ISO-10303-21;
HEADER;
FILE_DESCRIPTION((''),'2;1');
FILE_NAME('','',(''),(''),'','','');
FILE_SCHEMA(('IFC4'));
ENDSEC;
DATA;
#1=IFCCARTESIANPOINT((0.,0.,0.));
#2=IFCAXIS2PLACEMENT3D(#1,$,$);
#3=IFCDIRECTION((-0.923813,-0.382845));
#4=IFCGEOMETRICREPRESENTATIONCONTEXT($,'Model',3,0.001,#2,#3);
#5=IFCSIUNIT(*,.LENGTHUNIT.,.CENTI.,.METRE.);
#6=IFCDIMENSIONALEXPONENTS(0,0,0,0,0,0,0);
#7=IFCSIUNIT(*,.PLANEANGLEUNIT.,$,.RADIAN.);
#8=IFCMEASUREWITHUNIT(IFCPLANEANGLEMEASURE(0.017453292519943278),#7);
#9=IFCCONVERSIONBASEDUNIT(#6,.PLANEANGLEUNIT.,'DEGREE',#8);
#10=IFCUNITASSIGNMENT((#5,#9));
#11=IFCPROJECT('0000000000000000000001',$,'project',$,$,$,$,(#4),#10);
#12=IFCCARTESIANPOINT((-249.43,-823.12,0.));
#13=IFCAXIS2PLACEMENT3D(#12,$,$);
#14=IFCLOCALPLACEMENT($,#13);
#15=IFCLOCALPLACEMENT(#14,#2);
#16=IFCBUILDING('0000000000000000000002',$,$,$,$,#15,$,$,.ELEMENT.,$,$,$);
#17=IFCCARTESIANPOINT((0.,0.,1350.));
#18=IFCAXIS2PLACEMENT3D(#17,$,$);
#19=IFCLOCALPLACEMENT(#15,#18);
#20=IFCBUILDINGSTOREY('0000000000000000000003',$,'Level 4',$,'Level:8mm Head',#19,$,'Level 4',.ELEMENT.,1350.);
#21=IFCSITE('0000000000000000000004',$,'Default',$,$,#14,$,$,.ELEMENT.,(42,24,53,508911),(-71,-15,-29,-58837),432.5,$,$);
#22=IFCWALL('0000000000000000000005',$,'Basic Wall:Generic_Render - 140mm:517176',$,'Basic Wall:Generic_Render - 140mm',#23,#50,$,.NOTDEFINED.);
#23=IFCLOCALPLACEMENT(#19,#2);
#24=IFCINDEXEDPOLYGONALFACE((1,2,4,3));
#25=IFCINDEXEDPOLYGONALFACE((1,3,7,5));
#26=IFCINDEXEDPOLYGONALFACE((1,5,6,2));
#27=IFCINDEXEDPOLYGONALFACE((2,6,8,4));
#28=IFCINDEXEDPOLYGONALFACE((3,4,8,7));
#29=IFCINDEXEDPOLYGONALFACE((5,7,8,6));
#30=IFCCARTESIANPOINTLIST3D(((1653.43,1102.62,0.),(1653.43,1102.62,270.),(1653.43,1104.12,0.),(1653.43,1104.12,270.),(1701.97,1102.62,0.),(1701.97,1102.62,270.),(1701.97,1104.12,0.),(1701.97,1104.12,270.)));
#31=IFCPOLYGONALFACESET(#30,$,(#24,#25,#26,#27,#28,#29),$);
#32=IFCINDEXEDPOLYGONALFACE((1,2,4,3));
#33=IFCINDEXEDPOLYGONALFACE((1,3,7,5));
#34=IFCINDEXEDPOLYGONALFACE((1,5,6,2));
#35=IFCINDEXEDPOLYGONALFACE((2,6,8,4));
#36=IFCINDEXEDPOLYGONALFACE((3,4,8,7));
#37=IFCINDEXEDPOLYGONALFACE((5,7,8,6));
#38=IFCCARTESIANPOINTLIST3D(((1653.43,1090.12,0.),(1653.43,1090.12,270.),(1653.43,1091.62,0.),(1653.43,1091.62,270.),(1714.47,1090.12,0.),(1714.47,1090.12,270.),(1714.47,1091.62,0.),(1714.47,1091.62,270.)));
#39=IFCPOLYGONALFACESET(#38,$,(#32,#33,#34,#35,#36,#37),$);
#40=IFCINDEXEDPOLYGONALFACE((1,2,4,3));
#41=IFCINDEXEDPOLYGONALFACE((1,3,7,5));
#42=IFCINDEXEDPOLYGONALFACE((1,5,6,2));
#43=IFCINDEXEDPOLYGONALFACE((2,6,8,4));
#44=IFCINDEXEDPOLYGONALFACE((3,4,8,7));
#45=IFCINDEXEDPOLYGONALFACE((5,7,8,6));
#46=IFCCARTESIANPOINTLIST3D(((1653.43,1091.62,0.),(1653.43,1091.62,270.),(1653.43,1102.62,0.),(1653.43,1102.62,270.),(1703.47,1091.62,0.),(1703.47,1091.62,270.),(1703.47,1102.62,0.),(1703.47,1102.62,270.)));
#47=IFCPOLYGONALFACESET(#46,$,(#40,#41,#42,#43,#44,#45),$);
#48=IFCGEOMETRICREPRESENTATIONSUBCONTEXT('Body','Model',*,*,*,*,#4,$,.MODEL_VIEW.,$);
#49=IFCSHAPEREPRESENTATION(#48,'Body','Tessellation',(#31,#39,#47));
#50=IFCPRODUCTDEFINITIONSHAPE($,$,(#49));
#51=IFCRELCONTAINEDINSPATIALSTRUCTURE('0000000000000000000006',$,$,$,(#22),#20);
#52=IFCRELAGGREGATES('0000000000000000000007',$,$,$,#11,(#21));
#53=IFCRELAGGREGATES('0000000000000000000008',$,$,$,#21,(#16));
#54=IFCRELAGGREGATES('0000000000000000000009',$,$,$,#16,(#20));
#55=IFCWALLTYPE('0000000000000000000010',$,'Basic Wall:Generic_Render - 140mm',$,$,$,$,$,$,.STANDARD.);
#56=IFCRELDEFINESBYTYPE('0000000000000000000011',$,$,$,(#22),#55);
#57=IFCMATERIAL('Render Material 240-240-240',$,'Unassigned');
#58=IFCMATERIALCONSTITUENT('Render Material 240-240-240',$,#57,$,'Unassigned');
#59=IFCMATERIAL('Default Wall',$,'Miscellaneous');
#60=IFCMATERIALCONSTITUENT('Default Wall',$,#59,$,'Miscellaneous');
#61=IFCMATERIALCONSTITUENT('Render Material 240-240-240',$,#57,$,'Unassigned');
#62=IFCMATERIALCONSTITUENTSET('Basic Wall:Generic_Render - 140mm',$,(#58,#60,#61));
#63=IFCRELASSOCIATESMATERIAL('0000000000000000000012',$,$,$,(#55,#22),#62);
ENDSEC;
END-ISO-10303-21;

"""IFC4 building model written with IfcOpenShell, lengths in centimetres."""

from ifc_helpers import new_model, entity, si_unit, converted_unit, direction, frame, origin, place, context, subcontext, project, spatial, indexed_curve, outline, extrude, material, constituent, constituent_set, type_object, element, save


model = new_model("IFC4")

# Units and contexts
model_context = context("Model", 3, precision=0.001, world=origin(), true_north=direction((-0.923813, -0.382845)))
body_context = subcontext(model_context, "Body", "Model", "MODEL_VIEW")
ifc_project = project(units=[si_unit("LENGTHUNIT", "METRE", prefix="CENTI"), converted_unit("PLANEANGLEUNIT", "DEGREE", entity("IfcPlaneAngleMeasure", 0.017453292519943278), si_unit("PLANEANGLEUNIT", "RADIAN"), dimensions=[0, 0, 0, 0, 0, 0, 0])], contexts=[model_context])

# Site, building, storey
site_placement = place(None, frame((-249.43, -823.12, 0.0)))
site = spatial("IfcSite", under=ifc_project, at=site_placement, Name="Default", CompositionType="ELEMENT", RefLatitude=(42, 24, 53, 508911), RefLongitude=(-71, -15, -29, -58837), RefElevation=432.5)
building_placement = place(site_placement, origin())
building = spatial("IfcBuilding", under=site, at=building_placement, CompositionType="ELEMENT")
storey_placement = place(building_placement, frame((0.0, 0.0, 1350.0)))
storey = spatial("IfcBuildingStorey", under=building, at=storey_placement, Name="Level 4", ObjectType="Level:8mm Head", LongName="Level 4", CompositionType="ELEMENT", Elevation=1350.0)

# Wall
ifc_material_1 = material(Name="Render Material 240-240-240", Category="Unassigned")
ifc_material_2 = material(Name="Default Wall", Category="Miscellaneous")
ifc_constituent_1 = constituent(ifc_material_1, Name="Render Material 240-240-240", Category="Unassigned")
ifc_constituent_2 = constituent(ifc_material_2, Name="Default Wall", Category="Miscellaneous")
ifc_constituent_3 = constituent(ifc_material_1, Name="Render Material 240-240-240", Category="Unassigned")
ifc_constituent_set_1 = constituent_set(constituents=[ifc_constituent_1, ifc_constituent_2, ifc_constituent_3], Name="Basic Wall:Generic_Render - 140mm")
wall_type_1 = type_object("IfcWallType", Name="Basic Wall:Generic_Render - 140mm", PredefinedType="STANDARD", material=ifc_constituent_set_1)
wall_1_placement = place(storey_placement, frame((1701.97, 1097.12, 0.0), z_axis=(0.0, 0.0, 1.0), x_axis=(-1.0, 0.0, 0.0)))
element("IfcWall", 1, at=wall_1_placement, inside=storey, type_object=wall_type_1, material=ifc_constituent_set_1, Name="Basic Wall:Generic_Render - 140mm:517176", ObjectType="Basic Wall:Generic_Render - 140mm", PredefinedType="NOTDEFINED", context=body_context, shape_type="SweptSolid", body=[
    extrude(outline(indexed_curve([(-0.75, -24.27), (0.75, -24.27), (0.75, 24.27), (-0.75, 24.27), (-0.75, -24.27)], self_intersect=False)), frame((24.27, -6.25, 0.0), z_axis=(0.0, 0.0, 1.0), x_axis=(0.0, 1.0, 0.0)), (0.0, 0.0, 1.0), 270.0),
    extrude(outline(indexed_curve([(-0.75, -30.52), (0.75, -30.52), (0.75, 30.52), (-0.75, 30.52), (-0.75, -30.52)], self_intersect=False)), frame((18.02, 6.25, 0.0), z_axis=(0.0, 0.0, 1.0), x_axis=(0.0, -1.0, 0.0)), (0.0, 0.0, 1.0), 270.0),
    extrude(outline(indexed_curve([(-25.02, -5.5), (25.02, -5.5), (25.02, 5.5), (-25.02, 5.5), (-25.02, -5.5)], self_intersect=False)), frame((23.52, 0.0, 0.0)), (0.0, 0.0, 1.0), 270.0),
])

save(model, "model.ifc")
